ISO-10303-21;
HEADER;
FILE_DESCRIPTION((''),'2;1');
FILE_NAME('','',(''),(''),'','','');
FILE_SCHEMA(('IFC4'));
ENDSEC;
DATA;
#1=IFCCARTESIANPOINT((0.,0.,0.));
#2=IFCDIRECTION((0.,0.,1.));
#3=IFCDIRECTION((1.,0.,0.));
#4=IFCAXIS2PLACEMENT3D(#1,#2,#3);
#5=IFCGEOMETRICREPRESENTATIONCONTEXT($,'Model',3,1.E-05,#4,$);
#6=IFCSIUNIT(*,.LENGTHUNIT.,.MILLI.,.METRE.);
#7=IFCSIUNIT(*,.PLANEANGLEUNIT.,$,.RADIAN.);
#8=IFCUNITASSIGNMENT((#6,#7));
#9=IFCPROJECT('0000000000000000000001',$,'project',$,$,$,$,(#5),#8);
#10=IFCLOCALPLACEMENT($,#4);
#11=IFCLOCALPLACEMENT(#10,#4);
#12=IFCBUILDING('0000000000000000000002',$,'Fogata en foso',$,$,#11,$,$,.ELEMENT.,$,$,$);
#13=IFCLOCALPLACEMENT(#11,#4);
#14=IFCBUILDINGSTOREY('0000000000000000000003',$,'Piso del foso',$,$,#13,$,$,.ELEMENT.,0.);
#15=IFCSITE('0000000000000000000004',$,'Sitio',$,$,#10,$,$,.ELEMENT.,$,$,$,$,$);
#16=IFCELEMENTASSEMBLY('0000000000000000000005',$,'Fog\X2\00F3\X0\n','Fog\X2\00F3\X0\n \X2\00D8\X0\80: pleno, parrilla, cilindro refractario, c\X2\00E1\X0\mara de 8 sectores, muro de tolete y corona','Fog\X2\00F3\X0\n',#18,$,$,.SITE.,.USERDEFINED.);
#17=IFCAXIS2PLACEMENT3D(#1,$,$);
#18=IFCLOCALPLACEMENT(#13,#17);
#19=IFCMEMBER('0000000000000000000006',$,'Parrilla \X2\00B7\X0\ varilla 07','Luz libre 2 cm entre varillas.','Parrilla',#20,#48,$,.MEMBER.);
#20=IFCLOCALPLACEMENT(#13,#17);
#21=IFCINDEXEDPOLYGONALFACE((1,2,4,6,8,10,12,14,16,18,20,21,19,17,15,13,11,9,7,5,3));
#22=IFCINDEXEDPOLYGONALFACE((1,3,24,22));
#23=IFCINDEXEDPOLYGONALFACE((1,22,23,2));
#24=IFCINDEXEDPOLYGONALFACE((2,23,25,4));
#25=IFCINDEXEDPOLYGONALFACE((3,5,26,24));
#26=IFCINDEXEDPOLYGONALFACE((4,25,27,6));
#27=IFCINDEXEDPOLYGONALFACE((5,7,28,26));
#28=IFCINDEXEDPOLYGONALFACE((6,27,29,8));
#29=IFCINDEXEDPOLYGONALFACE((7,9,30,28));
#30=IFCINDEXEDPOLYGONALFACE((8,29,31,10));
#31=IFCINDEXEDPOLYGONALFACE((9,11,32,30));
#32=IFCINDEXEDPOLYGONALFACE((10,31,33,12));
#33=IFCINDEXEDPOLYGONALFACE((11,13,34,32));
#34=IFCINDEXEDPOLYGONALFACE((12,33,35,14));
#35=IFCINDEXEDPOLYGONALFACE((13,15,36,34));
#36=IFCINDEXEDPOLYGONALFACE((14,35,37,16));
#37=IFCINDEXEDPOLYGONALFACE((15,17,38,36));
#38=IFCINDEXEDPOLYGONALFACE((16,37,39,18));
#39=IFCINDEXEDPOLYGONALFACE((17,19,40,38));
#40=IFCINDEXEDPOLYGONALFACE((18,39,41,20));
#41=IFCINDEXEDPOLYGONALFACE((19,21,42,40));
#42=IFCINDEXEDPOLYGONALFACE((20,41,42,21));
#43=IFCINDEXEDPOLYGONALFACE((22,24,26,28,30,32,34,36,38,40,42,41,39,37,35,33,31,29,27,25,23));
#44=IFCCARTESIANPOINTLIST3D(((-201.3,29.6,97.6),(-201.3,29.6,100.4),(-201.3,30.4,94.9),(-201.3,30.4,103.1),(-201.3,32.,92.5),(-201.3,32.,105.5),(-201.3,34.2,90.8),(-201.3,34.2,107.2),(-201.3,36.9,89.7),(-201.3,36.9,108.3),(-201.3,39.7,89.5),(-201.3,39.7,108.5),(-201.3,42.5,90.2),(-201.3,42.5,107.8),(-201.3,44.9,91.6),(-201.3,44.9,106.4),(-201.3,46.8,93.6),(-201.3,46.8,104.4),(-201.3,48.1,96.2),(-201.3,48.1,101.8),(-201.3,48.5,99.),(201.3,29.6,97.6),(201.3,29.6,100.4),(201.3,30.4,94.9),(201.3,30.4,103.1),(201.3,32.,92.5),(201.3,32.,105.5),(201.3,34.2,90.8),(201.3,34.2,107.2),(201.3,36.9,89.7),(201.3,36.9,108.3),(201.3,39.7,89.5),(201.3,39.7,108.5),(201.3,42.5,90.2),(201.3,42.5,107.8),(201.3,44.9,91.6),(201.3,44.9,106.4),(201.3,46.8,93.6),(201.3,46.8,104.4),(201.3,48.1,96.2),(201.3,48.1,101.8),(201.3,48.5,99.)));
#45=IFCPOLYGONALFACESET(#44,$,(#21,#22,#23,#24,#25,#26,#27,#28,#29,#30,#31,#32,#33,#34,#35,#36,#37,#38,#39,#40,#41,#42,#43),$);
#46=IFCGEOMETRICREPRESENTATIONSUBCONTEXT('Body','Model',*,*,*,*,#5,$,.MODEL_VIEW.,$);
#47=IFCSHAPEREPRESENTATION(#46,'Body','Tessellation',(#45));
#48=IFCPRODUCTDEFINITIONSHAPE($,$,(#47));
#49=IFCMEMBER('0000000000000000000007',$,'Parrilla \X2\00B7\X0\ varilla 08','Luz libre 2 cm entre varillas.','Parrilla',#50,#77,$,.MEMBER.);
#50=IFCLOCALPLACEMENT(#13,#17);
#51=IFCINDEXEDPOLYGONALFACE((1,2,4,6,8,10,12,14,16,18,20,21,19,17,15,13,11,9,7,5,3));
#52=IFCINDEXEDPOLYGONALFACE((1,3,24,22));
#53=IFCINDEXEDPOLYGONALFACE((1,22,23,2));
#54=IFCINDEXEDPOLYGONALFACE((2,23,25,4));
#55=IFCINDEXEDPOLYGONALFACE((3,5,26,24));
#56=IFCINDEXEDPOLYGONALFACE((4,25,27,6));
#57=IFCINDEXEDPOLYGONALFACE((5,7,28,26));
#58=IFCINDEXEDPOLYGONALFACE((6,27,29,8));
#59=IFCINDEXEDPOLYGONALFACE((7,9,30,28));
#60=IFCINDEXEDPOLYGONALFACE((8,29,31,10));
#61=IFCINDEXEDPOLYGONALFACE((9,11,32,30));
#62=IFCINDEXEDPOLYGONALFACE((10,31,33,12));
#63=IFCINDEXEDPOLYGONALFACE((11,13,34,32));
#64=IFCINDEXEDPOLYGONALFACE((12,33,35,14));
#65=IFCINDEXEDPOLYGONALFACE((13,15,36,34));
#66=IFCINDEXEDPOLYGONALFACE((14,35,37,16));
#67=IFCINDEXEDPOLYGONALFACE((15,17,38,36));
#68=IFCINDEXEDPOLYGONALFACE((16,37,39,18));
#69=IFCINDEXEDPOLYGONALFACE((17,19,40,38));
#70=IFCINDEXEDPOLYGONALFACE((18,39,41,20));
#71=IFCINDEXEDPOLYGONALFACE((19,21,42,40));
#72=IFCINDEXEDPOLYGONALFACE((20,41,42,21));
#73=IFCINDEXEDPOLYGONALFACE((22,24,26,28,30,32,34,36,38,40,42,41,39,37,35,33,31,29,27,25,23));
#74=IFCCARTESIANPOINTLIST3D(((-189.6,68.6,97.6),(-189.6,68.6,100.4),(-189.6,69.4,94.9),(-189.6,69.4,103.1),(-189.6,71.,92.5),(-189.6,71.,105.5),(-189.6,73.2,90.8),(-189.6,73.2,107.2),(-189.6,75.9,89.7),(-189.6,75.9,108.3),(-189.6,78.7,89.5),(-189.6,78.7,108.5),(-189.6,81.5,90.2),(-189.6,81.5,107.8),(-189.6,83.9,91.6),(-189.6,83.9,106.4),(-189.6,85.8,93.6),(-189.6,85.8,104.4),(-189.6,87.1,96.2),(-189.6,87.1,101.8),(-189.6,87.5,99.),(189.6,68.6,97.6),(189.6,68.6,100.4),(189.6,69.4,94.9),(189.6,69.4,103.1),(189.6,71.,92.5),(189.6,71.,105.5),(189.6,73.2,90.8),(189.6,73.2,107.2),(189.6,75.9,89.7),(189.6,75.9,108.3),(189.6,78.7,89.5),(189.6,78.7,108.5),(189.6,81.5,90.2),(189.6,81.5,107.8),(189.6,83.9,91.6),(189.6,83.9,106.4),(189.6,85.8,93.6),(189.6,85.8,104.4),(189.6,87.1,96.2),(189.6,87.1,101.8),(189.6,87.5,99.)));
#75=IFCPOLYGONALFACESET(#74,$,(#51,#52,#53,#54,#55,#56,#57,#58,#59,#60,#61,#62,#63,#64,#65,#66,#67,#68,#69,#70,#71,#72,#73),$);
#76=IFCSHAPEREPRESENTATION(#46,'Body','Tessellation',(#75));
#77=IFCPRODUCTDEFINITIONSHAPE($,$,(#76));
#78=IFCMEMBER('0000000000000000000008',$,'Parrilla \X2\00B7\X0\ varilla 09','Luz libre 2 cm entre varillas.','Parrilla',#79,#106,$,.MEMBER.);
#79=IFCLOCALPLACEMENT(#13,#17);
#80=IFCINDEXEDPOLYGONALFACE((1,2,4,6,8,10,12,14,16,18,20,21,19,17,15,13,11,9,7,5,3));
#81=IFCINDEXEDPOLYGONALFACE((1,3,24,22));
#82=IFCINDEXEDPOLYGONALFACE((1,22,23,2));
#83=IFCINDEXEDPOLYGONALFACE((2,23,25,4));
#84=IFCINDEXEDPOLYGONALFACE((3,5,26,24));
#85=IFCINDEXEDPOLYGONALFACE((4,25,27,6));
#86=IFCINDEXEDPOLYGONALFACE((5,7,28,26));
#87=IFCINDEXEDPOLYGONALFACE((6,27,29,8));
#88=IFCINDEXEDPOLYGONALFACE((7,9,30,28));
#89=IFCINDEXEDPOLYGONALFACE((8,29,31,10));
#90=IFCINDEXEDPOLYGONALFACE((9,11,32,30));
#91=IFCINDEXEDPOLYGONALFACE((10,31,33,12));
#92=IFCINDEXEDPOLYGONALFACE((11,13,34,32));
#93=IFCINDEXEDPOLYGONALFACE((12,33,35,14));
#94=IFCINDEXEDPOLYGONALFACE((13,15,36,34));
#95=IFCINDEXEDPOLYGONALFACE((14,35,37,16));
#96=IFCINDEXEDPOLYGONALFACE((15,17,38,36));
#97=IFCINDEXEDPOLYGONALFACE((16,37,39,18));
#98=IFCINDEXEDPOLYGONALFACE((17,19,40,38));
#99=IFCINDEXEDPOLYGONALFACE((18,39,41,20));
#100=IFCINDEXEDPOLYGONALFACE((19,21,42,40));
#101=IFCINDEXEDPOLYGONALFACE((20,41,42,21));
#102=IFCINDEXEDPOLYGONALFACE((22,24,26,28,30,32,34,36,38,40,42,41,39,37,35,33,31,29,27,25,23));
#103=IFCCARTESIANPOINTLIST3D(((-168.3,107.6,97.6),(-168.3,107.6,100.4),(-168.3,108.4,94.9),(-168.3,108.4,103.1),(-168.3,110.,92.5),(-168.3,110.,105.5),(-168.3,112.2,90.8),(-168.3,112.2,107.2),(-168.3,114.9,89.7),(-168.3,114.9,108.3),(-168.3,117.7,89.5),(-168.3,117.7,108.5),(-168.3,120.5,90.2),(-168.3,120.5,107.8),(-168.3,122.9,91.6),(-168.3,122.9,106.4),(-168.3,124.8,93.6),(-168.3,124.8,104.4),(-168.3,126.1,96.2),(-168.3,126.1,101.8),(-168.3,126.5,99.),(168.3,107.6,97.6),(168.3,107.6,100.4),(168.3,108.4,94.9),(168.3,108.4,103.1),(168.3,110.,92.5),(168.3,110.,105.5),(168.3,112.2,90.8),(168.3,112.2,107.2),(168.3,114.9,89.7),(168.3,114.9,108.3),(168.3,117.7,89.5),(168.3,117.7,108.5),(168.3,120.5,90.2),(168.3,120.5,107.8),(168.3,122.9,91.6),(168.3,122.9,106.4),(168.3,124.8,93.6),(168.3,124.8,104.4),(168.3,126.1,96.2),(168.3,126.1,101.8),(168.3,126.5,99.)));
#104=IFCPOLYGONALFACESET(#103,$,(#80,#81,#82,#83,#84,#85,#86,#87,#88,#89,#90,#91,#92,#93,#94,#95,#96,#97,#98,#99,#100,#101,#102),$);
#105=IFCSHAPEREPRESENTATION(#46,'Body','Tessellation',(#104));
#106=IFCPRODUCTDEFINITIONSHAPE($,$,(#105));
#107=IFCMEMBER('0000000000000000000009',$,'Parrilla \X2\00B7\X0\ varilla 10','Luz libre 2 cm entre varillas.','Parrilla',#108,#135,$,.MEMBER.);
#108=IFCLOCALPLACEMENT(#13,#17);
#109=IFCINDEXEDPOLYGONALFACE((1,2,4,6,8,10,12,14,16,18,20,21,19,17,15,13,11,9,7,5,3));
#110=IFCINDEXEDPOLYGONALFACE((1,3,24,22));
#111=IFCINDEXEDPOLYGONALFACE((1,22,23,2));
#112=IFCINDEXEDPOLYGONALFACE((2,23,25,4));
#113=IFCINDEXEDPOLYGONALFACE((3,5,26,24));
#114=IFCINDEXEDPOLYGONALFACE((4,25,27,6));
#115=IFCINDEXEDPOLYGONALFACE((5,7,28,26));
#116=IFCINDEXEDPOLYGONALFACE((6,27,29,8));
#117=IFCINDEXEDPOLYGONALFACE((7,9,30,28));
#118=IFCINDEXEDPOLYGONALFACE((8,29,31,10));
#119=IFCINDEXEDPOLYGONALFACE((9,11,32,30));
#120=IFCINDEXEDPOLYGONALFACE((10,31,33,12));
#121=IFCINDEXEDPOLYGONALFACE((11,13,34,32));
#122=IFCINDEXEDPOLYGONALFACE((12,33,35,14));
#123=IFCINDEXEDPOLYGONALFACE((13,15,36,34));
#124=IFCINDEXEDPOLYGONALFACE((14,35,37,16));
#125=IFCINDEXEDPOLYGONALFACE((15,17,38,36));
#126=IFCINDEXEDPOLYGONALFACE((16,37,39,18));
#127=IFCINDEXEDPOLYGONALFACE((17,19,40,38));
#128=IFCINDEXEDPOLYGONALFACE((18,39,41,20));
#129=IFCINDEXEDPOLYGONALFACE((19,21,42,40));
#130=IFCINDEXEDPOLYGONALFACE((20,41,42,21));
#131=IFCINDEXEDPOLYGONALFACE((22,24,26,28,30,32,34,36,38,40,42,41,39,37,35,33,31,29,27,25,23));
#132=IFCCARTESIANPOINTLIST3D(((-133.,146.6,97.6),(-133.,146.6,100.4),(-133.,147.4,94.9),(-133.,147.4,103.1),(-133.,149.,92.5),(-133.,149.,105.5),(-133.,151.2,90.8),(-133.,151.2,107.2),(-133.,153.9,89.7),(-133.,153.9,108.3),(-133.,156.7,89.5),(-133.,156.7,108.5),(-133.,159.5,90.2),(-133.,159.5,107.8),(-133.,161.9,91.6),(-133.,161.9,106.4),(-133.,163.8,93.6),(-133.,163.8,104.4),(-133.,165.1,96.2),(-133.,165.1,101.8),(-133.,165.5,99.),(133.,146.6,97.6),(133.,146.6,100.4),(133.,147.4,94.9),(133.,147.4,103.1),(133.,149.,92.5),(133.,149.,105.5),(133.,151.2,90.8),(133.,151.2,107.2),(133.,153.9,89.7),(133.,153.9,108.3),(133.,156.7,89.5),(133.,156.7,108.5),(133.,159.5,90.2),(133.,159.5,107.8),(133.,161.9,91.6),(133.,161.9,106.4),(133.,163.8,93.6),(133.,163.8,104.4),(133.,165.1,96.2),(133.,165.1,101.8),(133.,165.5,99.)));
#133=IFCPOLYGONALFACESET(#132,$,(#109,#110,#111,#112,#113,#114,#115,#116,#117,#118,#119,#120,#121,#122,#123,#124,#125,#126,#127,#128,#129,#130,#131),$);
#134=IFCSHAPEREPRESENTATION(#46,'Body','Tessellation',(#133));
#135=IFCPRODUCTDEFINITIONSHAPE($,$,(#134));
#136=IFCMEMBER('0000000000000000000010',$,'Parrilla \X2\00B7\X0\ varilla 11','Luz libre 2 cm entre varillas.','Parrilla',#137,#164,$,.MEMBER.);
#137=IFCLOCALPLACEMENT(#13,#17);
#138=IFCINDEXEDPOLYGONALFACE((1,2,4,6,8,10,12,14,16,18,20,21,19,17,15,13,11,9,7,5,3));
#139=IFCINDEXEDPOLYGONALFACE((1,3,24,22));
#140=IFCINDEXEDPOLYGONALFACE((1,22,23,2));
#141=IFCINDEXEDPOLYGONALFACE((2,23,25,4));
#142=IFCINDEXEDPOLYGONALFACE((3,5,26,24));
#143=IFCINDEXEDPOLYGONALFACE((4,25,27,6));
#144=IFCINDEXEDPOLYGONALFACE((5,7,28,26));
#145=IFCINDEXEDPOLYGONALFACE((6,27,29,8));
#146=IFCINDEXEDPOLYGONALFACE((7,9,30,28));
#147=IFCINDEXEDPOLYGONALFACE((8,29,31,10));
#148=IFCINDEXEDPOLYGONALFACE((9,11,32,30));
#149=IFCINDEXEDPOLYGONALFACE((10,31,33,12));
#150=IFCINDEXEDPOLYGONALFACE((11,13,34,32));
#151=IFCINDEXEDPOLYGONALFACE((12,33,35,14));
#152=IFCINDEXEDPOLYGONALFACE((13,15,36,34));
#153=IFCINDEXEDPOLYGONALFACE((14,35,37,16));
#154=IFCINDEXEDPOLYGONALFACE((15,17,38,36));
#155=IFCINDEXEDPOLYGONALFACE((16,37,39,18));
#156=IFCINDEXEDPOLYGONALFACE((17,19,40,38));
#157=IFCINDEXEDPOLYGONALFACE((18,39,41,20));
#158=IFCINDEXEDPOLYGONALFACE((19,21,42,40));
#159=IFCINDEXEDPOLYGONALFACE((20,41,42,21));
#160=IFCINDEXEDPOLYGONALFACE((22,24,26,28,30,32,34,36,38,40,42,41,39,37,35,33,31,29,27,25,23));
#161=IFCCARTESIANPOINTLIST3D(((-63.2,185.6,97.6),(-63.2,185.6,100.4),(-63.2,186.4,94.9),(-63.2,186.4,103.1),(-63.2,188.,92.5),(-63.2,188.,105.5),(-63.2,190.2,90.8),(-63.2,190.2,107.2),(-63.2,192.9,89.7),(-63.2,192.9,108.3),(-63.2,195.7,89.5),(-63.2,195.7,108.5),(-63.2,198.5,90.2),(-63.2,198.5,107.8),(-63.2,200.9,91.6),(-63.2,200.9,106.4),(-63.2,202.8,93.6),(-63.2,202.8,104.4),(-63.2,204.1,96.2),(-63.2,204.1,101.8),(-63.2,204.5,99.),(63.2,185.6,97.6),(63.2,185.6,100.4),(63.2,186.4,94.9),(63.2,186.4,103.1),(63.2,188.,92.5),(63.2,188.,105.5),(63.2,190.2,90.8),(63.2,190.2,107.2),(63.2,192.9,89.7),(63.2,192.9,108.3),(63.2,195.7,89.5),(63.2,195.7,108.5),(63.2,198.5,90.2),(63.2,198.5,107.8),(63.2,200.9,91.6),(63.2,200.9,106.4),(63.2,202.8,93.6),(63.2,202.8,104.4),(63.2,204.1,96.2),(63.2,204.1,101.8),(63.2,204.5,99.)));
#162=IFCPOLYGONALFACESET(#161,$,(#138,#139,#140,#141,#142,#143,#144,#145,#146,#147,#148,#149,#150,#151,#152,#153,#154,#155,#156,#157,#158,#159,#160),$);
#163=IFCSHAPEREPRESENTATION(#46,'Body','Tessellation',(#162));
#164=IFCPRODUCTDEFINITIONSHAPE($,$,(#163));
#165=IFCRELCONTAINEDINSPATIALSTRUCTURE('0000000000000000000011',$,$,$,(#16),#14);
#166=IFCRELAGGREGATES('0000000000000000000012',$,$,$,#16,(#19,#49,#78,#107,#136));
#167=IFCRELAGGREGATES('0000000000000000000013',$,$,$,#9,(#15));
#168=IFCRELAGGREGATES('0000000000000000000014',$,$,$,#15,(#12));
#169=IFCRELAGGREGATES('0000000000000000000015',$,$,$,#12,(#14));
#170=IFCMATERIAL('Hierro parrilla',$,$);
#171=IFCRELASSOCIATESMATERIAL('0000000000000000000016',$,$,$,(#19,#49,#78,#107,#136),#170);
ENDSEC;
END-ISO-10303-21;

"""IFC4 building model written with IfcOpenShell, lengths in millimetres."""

from ifc_helpers import new_model, si_unit, frame, origin_with_axes, origin_2d, place, context, subcontext, project, spatial, circle, extrude, material, element, aggregate, save


model = new_model("IFC4")

# Units and contexts
model_context = context("Model", 3, precision=1e-05, world=origin_with_axes())
body_context = subcontext(model_context, "Body", "Model", "MODEL_VIEW")
ifc_project = project(units=[si_unit("LENGTHUNIT", "METRE", prefix="MILLI"), si_unit("PLANEANGLEUNIT", "RADIAN")], contexts=[model_context])

# Site, building, storey
site_placement = place(None, origin_with_axes())
site = spatial("IfcSite", under=ifc_project, at=site_placement, Name="Sitio", CompositionType="ELEMENT")
building_placement = place(site_placement, origin_with_axes())
building = spatial("IfcBuilding", under=site, at=building_placement, Name="Fogata en foso", CompositionType="ELEMENT")
storey_placement = place(building_placement, origin_with_axes())
storey = spatial("IfcBuildingStorey", under=building, at=storey_placement, Name="Piso del foso", CompositionType="ELEMENT", Elevation=0.0)

# Element assembly, members
assembly_1_placement = place(storey_placement, origin_with_axes())
assembly_1 = element("IfcElementAssembly", 1, at=assembly_1_placement, inside=storey, Name="Fogón", Description="Fogón Ø80: pleno, parrilla, cilindro refractario, cámara de 8 sectores, muro de tolete y corona", ObjectType="Fogón", AssemblyPlace="SITE", PredefinedType="USERDEFINED")
ifc_material_1 = material(Name="Hierro parrilla")
member_1_placement = place(storey_placement, frame((-201.3, 39.0, 99.0), z_axis=(1.0, 0.0, 0.0), x_axis=(0.0, 1.0, 0.0)))
member_1 = element("IfcMember", 2, at=member_1_placement, material=ifc_material_1, Name="Parrilla · varilla 07", Description="Luz libre 2 cm entre varillas.", ObjectType="Parrilla", PredefinedType="MEMBER", context=body_context, shape_type="SweptSolid", body=[
    extrude(circle(Radius=9.5, at=origin_2d()), origin_with_axes(), (0.0, 0.0, 1.0), 402.5),
])
member_2_placement = place(storey_placement, frame((-189.6, 78.0, 99.0), z_axis=(1.0, 0.0, 0.0), x_axis=(0.0, 1.0, 0.0)))
member_2 = element("IfcMember", 3, at=member_2_placement, material=ifc_material_1, Name="Parrilla · varilla 08", Description="Luz libre 2 cm entre varillas.", ObjectType="Parrilla", PredefinedType="MEMBER", context=body_context, shape_type="SweptSolid", body=[
    extrude(circle(Radius=9.5, at=origin_2d()), origin_with_axes(), (0.0, 0.0, 1.0), 379.2),
])
member_3_placement = place(storey_placement, frame((-168.3, 117.0, 99.0), z_axis=(1.0, 0.0, 0.0), x_axis=(0.0, 1.0, 0.0)))
member_3 = element("IfcMember", 4, at=member_3_placement, material=ifc_material_1, Name="Parrilla · varilla 09", Description="Luz libre 2 cm entre varillas.", ObjectType="Parrilla", PredefinedType="MEMBER", context=body_context, shape_type="SweptSolid", body=[
    extrude(circle(Radius=9.5, at=origin_2d()), origin_with_axes(), (0.0, 0.0, 1.0), 336.7),
])
member_4_placement = place(storey_placement, frame((-133.0, 156.0, 99.0), z_axis=(1.0, 0.0, 0.0), x_axis=(0.0, 1.0, 0.0)))
member_4 = element("IfcMember", 5, at=member_4_placement, material=ifc_material_1, Name="Parrilla · varilla 10", Description="Luz libre 2 cm entre varillas.", ObjectType="Parrilla", PredefinedType="MEMBER", context=body_context, shape_type="SweptSolid", body=[
    extrude(circle(Radius=9.5, at=origin_2d()), origin_with_axes(), (0.0, 0.0, 1.0), 266.0),
])
member_5_placement = place(storey_placement, frame((-63.2, 195.0, 99.0), z_axis=(1.0, 0.0, 0.0), x_axis=(0.0, 1.0, 0.0)))
member_5 = element("IfcMember", 6, at=member_5_placement, material=ifc_material_1, Name="Parrilla · varilla 11", Description="Luz libre 2 cm entre varillas.", ObjectType="Parrilla", PredefinedType="MEMBER", context=body_context, shape_type="SweptSolid", body=[
    extrude(circle(Radius=9.5, at=origin_2d()), origin_with_axes(), (0.0, 0.0, 1.0), 126.5),
])

aggregate(assembly_1, [member_1, member_2, member_3, member_4, member_5])

save(model, "model.ifc")
